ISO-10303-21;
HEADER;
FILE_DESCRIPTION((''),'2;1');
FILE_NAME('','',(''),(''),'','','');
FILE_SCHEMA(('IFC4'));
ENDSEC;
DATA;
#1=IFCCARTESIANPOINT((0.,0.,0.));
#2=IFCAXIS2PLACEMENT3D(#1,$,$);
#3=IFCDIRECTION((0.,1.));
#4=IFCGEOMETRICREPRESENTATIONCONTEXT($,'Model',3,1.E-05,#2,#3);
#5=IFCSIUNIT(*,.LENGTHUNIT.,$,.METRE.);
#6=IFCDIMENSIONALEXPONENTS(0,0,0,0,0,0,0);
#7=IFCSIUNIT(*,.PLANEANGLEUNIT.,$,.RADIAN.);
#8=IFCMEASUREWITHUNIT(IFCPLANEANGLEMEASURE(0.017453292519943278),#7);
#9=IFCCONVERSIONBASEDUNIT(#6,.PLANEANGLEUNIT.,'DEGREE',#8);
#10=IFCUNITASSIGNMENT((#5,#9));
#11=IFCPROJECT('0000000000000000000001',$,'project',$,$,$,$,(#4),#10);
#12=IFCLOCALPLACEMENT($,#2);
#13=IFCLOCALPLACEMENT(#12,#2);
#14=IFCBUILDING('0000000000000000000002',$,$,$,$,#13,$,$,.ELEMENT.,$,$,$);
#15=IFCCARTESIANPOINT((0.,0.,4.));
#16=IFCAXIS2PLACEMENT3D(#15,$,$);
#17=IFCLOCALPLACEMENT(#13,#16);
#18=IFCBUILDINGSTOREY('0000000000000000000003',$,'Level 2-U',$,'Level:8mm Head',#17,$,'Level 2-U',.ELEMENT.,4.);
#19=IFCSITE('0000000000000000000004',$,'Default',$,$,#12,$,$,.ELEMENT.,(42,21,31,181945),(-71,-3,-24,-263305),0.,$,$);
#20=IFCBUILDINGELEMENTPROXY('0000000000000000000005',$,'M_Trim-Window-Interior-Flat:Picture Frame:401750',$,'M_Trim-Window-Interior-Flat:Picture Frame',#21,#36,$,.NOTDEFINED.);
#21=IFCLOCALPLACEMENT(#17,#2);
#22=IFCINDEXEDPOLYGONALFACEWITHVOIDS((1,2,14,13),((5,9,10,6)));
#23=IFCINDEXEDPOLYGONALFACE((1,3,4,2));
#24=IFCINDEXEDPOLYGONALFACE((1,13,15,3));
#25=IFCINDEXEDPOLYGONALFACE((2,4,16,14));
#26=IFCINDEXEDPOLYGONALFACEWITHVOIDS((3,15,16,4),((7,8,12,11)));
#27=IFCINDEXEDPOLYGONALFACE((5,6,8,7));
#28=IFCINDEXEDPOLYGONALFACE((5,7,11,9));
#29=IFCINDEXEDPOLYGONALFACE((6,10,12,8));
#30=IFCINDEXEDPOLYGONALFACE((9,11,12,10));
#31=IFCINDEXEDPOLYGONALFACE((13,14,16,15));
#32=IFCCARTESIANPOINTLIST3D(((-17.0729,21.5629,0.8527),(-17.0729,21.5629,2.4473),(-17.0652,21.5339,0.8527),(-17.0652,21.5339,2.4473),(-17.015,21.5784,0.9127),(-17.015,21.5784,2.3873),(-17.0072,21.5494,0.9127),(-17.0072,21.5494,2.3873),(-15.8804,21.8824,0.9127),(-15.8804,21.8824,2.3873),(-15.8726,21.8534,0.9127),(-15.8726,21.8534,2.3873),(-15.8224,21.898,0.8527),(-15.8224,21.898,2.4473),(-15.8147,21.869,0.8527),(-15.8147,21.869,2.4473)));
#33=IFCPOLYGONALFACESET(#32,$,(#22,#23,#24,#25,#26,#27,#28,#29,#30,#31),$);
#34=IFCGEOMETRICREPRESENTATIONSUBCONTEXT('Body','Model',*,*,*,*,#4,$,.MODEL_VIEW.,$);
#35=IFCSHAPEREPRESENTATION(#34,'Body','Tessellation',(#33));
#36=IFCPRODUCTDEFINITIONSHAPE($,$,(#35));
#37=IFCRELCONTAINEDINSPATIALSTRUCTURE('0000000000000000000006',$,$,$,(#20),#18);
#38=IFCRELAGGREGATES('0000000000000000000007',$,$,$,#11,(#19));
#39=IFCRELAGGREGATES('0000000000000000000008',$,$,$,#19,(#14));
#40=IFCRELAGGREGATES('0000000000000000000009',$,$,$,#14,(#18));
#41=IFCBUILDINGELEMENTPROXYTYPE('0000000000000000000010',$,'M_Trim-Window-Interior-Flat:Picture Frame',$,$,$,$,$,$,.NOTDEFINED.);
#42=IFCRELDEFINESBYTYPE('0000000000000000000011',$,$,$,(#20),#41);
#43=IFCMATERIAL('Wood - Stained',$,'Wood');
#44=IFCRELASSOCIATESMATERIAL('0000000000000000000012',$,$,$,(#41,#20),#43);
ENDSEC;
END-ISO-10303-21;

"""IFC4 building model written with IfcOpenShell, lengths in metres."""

from ifc_helpers import new_model, entity, si_unit, converted_unit, direction, frame, origin, place, context, subcontext, project, spatial, polyline, outline, extrude, source, transform, mapped, material, type_object, type_shapes, element, save


model = new_model("IFC4")

# Units and contexts
model_context = context("Model", 3, precision=1e-05, world=origin(), true_north=direction((0.0, 1.0)))
body_context = subcontext(model_context, "Body", "Model", "MODEL_VIEW")
ifc_project = project(units=[si_unit("LENGTHUNIT", "METRE"), converted_unit("PLANEANGLEUNIT", "DEGREE", entity("IfcPlaneAngleMeasure", 0.017453292519943278), si_unit("PLANEANGLEUNIT", "RADIAN"), dimensions=[0, 0, 0, 0, 0, 0, 0])], contexts=[model_context])

# Site, building, storey
site_placement = place(None, origin())
site = spatial("IfcSite", under=ifc_project, at=site_placement, Name="Default", CompositionType="ELEMENT", RefLatitude=(42, 21, 31, 181945), RefLongitude=(-71, -3, -24, -263305), RefElevation=0.0)
building_placement = place(site_placement, origin())
building = spatial("IfcBuilding", under=site, at=building_placement, CompositionType="ELEMENT")
storey_placement = place(building_placement, frame((0.0, 0.0, 4.0)))
storey = spatial("IfcBuildingStorey", under=building, at=storey_placement, Name="Level 2-U", ObjectType="Level:8mm Head", LongName="Level 2-U", CompositionType="ELEMENT", Elevation=4.0)

# Building element proxy
ifc_material_1 = material(Name="Wood - Stained", Category="Wood")
building_element_proxy_type_1 = type_object("IfcBuildingElementProxyType", Name="M_Trim-Window-Interior-Flat:Picture Frame", PredefinedType="NOTDEFINED", material=ifc_material_1)
shared_shape_1 = source(origin(), body_context, "Body", "SweptSolid", [
    extrude(outline(polyline([(-0.6473, -0.7973), (0.6473, -0.7973), (0.6473, 0.7973), (-0.6473, 0.7973), (-0.6473, -0.7973)]), holes=[polyline([(-0.5873, -0.7373), (-0.5873, 0.7373), (0.5873, 0.7373), (0.5873, -0.7373), (-0.5873, -0.7373)])]), frame((0.0, -0.75, 0.0), z_axis=(0.0, 0.0, 1.0), x_axis=(-1.0, 0.0, 0.0)), (0.0, 0.0, 1.0), 0.03),
])
type_shapes(building_element_proxy_type_1, [shared_shape_1])
for number, where, z_axis, x_axis, name in (
    (1, (-16.4477, 21.7304, 2.4), (0.258819, -0.965926, 0.0), (0.965926, 0.258819, 0.0), "M_Trim-Window-Interior-Flat:Picture Frame:401750"),
):
    element("IfcBuildingElementProxy", number, at=place(storey_placement, frame(where, z_axis=z_axis, x_axis=x_axis)), inside=storey, type_object=building_element_proxy_type_1, material=ifc_material_1, Name=name, ObjectType="M_Trim-Window-Interior-Flat:Picture Frame", PredefinedType="NOTDEFINED", context=body_context, shape_type="MappedRepresentation", body=[
        mapped(shared_shape_1, transform((0.0, 0.0, 0.0), scale=1.0)),
    ])

save(model, "model.ifc")
